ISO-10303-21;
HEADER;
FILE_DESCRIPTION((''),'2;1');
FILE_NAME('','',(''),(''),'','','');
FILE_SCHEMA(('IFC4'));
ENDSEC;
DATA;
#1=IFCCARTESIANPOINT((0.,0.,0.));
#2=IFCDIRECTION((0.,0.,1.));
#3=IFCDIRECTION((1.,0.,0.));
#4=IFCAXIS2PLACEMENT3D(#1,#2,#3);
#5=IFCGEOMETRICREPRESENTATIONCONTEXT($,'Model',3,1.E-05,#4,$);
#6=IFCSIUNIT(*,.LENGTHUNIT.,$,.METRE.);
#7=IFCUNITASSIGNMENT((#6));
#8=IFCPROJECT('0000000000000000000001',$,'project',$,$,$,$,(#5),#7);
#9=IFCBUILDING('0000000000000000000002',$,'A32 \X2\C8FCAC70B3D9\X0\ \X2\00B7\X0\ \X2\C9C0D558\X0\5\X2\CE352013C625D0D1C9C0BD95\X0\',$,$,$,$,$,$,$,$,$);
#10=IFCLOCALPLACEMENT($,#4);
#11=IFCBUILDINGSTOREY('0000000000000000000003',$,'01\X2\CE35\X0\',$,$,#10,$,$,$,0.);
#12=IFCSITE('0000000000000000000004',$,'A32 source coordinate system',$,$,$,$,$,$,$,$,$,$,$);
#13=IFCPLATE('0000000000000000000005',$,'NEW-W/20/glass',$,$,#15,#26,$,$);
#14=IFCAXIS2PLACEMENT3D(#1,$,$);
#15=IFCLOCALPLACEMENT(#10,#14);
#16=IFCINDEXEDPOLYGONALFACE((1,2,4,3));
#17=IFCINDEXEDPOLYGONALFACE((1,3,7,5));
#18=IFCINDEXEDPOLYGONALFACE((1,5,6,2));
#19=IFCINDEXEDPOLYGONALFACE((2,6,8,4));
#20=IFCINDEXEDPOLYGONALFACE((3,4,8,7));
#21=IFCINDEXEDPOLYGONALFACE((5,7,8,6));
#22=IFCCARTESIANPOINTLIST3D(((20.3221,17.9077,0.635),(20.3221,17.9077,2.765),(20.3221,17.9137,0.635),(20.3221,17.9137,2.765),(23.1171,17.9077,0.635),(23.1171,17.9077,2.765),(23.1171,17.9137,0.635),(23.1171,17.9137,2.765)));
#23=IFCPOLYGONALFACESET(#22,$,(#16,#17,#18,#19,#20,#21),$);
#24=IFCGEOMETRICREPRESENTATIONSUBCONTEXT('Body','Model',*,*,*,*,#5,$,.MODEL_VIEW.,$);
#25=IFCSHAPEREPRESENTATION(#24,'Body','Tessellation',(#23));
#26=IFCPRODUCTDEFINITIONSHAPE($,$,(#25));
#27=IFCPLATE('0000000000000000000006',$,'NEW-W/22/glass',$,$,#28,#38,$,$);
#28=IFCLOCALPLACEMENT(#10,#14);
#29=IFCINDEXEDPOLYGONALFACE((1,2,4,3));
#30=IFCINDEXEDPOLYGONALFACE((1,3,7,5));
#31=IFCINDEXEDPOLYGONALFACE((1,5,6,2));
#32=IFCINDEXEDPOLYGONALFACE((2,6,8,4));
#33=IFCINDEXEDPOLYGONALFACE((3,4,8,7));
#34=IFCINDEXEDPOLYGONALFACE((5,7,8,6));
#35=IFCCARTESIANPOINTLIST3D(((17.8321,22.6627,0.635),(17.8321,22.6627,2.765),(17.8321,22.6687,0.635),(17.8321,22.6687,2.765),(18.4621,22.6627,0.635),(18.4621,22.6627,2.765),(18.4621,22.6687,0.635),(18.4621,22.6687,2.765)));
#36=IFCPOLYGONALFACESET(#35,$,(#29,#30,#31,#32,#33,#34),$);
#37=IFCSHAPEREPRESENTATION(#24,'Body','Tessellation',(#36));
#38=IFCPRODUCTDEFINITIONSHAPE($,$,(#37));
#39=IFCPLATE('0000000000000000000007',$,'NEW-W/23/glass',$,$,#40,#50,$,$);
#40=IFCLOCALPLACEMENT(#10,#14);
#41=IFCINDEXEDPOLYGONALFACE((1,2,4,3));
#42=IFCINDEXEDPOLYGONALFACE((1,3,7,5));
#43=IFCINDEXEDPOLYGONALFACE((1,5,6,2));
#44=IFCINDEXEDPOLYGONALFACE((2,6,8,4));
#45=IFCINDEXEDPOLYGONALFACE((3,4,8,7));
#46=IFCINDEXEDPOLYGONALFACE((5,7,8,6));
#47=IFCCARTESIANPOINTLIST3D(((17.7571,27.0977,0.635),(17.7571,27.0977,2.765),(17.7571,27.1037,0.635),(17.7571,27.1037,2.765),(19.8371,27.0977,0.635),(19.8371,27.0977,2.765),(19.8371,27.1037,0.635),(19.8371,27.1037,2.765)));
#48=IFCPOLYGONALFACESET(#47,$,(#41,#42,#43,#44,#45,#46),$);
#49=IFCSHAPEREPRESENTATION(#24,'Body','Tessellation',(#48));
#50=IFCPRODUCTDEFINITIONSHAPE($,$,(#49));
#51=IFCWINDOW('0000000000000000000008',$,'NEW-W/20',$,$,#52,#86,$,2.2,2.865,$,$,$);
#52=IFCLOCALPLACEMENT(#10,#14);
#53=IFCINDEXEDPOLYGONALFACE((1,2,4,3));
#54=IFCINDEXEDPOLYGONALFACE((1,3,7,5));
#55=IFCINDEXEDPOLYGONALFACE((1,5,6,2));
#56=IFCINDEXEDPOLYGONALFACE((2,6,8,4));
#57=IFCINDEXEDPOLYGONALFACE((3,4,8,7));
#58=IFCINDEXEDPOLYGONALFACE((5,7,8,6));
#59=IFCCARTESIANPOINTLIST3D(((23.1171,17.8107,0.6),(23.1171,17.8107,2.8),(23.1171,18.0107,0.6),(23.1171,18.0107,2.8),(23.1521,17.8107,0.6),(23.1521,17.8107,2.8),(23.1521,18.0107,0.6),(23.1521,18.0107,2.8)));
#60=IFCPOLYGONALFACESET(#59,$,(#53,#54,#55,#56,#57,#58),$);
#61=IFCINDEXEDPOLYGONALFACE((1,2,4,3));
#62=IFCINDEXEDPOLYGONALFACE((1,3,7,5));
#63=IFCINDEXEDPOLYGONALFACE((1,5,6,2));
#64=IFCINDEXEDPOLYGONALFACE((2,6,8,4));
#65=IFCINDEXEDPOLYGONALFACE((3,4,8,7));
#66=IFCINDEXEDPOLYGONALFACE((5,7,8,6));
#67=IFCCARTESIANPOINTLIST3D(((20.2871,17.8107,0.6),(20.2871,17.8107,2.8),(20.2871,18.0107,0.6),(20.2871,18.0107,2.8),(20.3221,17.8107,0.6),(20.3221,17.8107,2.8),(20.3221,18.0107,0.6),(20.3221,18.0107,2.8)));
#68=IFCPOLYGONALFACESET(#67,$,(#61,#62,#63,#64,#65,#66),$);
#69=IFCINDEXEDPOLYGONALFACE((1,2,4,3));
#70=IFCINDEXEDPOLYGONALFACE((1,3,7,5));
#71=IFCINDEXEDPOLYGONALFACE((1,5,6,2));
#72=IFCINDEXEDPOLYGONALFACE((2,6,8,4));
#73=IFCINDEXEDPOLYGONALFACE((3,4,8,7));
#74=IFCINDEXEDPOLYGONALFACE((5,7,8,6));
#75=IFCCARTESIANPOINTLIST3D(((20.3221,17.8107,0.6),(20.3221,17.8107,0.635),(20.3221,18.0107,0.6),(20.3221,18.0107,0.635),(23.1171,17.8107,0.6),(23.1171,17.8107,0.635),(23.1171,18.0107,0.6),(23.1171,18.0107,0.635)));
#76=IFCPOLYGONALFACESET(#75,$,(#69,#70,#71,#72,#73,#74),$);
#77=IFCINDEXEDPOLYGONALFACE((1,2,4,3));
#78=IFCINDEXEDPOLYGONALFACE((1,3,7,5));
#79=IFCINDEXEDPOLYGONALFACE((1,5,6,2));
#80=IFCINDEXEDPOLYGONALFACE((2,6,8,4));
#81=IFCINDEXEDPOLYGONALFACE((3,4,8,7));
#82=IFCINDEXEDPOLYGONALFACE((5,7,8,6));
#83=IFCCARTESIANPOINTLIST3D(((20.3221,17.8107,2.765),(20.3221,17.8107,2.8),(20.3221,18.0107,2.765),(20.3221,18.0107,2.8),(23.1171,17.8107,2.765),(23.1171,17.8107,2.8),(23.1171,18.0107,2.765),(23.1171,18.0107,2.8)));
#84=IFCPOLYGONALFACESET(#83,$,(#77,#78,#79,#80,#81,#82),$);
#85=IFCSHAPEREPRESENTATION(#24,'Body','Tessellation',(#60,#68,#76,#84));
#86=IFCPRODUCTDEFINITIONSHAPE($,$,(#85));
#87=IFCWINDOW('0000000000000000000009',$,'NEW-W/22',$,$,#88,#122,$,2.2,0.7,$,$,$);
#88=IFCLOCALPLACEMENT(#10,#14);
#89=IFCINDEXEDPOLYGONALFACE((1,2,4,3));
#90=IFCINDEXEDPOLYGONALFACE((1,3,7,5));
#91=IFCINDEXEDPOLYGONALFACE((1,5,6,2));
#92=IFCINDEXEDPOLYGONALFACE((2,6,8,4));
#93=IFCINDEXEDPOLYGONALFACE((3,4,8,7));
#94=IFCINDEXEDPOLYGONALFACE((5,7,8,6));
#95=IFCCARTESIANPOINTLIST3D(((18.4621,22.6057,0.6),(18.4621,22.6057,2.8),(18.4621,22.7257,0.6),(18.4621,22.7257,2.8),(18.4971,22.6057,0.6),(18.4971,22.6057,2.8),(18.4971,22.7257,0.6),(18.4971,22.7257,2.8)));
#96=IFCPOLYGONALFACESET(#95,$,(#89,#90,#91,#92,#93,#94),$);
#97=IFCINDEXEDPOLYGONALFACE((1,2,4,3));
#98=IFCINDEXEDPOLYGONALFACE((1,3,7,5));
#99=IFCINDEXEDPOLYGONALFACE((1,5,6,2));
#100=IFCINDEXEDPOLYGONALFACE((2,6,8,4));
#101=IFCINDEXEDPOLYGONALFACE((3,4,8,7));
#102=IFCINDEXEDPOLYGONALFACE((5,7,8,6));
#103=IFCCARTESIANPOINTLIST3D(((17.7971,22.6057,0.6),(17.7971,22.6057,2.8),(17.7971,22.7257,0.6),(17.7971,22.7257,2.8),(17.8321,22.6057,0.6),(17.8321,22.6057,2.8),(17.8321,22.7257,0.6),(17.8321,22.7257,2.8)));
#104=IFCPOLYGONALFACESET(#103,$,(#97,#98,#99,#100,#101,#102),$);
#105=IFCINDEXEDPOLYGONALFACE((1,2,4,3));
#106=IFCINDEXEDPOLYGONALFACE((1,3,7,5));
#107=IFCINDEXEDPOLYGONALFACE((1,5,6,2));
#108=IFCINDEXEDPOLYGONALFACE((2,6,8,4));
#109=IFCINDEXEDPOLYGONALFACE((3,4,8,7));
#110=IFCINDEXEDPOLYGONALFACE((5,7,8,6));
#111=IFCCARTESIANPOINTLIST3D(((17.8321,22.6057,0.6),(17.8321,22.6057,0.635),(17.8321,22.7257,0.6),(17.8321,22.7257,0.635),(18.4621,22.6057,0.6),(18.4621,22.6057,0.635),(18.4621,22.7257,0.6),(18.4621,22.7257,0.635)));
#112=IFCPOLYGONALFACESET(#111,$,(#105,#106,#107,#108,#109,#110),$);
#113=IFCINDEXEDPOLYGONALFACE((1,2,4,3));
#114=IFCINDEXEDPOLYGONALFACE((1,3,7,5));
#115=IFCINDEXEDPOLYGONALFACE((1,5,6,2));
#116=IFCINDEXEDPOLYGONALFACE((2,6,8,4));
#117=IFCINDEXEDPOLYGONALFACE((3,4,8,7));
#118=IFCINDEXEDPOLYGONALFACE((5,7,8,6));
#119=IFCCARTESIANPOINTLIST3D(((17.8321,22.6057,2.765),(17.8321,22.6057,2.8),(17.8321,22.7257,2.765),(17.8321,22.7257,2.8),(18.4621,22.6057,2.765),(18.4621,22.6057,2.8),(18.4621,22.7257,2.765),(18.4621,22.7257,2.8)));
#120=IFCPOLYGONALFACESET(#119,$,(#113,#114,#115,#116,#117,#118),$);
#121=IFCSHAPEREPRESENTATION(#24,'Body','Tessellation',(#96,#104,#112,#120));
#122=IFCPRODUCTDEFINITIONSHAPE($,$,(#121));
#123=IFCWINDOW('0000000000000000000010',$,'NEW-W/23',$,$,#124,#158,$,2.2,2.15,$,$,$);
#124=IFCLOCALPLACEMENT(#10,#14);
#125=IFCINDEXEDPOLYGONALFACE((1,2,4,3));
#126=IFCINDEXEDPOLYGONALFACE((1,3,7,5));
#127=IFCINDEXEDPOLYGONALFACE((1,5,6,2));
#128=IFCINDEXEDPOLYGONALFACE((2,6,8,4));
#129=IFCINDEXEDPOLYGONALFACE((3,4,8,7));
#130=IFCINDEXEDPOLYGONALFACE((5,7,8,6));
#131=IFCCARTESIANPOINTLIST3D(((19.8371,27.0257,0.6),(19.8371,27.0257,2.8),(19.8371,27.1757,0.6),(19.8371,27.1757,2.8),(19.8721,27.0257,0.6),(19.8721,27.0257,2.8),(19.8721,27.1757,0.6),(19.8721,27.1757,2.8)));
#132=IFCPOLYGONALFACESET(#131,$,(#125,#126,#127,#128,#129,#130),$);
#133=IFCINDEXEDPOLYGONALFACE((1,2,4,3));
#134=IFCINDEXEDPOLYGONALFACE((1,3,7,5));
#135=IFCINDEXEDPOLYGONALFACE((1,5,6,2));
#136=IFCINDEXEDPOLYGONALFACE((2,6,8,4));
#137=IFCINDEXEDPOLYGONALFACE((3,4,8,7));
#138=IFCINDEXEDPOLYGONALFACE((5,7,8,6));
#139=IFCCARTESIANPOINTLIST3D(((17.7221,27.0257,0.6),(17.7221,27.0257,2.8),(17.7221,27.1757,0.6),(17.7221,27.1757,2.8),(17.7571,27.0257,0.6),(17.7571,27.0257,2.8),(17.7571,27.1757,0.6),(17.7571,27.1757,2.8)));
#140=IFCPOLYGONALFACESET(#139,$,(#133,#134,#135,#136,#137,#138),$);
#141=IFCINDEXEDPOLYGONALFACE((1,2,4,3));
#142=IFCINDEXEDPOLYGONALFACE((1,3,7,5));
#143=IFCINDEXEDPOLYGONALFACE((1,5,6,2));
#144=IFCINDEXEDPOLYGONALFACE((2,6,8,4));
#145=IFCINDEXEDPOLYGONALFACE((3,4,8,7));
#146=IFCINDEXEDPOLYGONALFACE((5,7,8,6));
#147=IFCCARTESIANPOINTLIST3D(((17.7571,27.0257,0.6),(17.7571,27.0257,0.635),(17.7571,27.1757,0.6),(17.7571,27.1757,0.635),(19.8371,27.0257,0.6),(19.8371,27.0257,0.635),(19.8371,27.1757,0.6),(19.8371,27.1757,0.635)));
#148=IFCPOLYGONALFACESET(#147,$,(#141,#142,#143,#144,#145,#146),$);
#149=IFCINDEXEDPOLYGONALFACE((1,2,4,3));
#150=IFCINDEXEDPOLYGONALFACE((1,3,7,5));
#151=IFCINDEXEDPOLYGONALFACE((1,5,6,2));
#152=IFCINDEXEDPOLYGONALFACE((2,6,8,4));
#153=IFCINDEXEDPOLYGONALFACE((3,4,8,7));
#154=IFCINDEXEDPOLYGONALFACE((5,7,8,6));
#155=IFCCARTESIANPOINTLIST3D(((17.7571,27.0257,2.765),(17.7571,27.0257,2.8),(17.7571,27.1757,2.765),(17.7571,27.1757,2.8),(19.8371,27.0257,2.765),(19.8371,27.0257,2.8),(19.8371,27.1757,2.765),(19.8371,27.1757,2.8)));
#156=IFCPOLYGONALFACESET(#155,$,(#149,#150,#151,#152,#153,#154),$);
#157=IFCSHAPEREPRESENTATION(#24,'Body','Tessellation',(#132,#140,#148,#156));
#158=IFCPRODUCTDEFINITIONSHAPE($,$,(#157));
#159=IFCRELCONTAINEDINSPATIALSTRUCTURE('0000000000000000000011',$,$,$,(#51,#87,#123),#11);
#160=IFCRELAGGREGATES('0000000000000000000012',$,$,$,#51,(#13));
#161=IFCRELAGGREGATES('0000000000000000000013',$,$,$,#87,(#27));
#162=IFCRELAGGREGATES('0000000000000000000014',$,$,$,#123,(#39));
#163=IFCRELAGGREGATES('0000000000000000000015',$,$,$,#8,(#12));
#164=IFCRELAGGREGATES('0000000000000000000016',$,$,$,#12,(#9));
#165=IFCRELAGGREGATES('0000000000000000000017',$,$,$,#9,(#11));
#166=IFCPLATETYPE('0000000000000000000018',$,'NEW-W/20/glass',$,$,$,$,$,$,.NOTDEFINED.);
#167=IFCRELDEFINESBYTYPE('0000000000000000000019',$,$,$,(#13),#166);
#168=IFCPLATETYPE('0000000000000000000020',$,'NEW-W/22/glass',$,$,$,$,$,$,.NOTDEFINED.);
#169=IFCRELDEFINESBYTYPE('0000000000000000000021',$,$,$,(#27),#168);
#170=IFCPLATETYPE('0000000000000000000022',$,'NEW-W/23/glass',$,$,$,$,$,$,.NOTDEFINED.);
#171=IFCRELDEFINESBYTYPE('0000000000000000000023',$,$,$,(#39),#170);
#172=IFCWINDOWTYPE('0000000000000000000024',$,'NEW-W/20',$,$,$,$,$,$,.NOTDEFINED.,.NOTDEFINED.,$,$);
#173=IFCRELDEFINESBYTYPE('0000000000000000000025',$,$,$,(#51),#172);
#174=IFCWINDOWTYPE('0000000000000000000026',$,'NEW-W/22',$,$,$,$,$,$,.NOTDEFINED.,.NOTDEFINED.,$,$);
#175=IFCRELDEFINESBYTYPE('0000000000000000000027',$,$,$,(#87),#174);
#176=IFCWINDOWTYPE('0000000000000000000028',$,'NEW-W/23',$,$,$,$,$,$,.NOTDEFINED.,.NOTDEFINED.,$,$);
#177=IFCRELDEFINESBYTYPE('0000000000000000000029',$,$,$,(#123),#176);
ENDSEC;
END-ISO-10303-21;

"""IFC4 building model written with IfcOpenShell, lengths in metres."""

from ifc_helpers import new_model, si_unit, frame, origin, origin_with_axes, place, context, subcontext, project, spatial, polyline, outline, extrude, source, transform, mapped, type_object, type_shapes, element, aggregate, save


model = new_model("IFC4")

# Units and contexts
model_context = context("Model", 3, precision=1e-05, world=origin_with_axes())
body_context = subcontext(model_context, "Body", "Model", "MODEL_VIEW")
ifc_project = project(units=[si_unit("LENGTHUNIT", "METRE")], contexts=[model_context])

# Plates
storey_placement = place(None, origin_with_axes())
plate_type_1 = type_object("IfcPlateType", Name="NEW-W/20/glass", PredefinedType="NOTDEFINED")
shared_shape_1 = source(origin(), body_context, "Body", "SweptSolid", [
    extrude(outline(polyline([(23.1171, 17.9077), (20.3221, 17.9077), (20.3221, 17.9137), (23.1171, 17.9137), (23.1171, 17.9077)])), frame((0.0, 0.0, 0.635)), (0.0, 0.0, 1.0), 2.13),
])
type_shapes(plate_type_1, [shared_shape_1])
window_1_placement = place(storey_placement, origin_with_axes())
plate_1_placement = place(window_1_placement, origin_with_axes())
plate_1 = element("IfcPlate", 1, at=plate_1_placement, type_object=plate_type_1, Name="NEW-W/20/glass", context=body_context, shape_type="MappedRepresentation", body=[
    mapped(shared_shape_1, transform((0.0, 0.0, 0.0), scale=1.0)),
])
plate_type_2 = type_object("IfcPlateType", Name="NEW-W/22/glass", PredefinedType="NOTDEFINED")
shared_shape_2 = source(origin(), body_context, "Body", "SweptSolid", [
    extrude(outline(polyline([(18.4621, 22.6627), (17.8321, 22.6627), (17.8321, 22.6687), (18.4621, 22.6687), (18.4621, 22.6627)])), frame((0.0, 0.0, 0.635)), (0.0, 0.0, 1.0), 2.13),
])
type_shapes(plate_type_2, [shared_shape_2])
window_2_placement = place(storey_placement, origin_with_axes())
plate_2_placement = place(window_2_placement, origin_with_axes())
plate_2 = element("IfcPlate", 2, at=plate_2_placement, type_object=plate_type_2, Name="NEW-W/22/glass", context=body_context, shape_type="MappedRepresentation", body=[
    mapped(shared_shape_2, transform((0.0, 0.0, 0.0), scale=1.0)),
])
plate_type_3 = type_object("IfcPlateType", Name="NEW-W/23/glass", PredefinedType="NOTDEFINED")
shared_shape_3 = source(origin(), body_context, "Body", "SweptSolid", [
    extrude(outline(polyline([(19.8371, 27.0977), (17.7571, 27.0977), (17.7571, 27.1037), (19.8371, 27.1037), (19.8371, 27.0977)])), frame((0.0, 0.0, 0.635)), (0.0, 0.0, 1.0), 2.13),
])
type_shapes(plate_type_3, [shared_shape_3])
window_3_placement = place(storey_placement, origin_with_axes())
plate_3_placement = place(window_3_placement, origin_with_axes())
plate_3 = element("IfcPlate", 3, at=plate_3_placement, type_object=plate_type_3, Name="NEW-W/23/glass", context=body_context, shape_type="MappedRepresentation", body=[
    mapped(shared_shape_3, transform((0.0, 0.0, 0.0), scale=1.0)),
])

# Site, building, storey
site = spatial("IfcSite", under=ifc_project, Name="A32 source coordinate system")
building = spatial("IfcBuilding", under=site, Name="A32 주거동 · 지하5층–옥탑지붕")
storey = spatial("IfcBuildingStorey", under=building, at=storey_placement, Name="01층", Elevation=0.0)

# Windows
window_type_1 = type_object("IfcWindowType", Name="NEW-W/20", PartitioningType="NOTDEFINED", PredefinedType="NOTDEFINED")
shared_shape_4 = source(origin(), body_context, "Body", "SweptSolid", [
    extrude(outline(polyline([(23.1171, 17.8107), (23.1171, 18.0107), (23.1521, 18.0107), (23.1521, 17.8107), (23.1171, 17.8107)])), frame((0.0, 0.0, 0.6)), (0.0, 0.0, 1.0), 2.2),
    extrude(outline(polyline([(20.2871, 17.8107), (20.2871, 18.0107), (20.3221, 18.0107), (20.3221, 17.8107), (20.2871, 17.8107)])), frame((0.0, 0.0, 0.6)), (0.0, 0.0, 1.0), 2.2),
    extrude(outline(polyline([(23.1171, 17.8107), (23.1171, 18.0107), (20.3221, 18.0107), (20.3221, 17.8107), (23.1171, 17.8107)])), frame((0.0, 0.0, 0.6)), (0.0, 0.0, 1.0), 0.035),
    extrude(outline(polyline([(23.1171, 17.8107), (23.1171, 18.0107), (20.3221, 18.0107), (20.3221, 17.8107), (23.1171, 17.8107)])), frame((0.0, 0.0, 2.765)), (0.0, 0.0, 1.0), 0.035),
])
type_shapes(window_type_1, [shared_shape_4])
window_1 = element("IfcWindow", 4, at=window_1_placement, inside=storey, type_object=window_type_1, Name="NEW-W/20", OverallHeight=2.2, OverallWidth=2.865, context=body_context, shape_type="MappedRepresentation", body=[
    mapped(shared_shape_4, transform((0.0, 0.0, 0.0), scale=1.0)),
])
aggregate(window_1, [plate_1])
window_type_2 = type_object("IfcWindowType", Name="NEW-W/22", PartitioningType="NOTDEFINED", PredefinedType="NOTDEFINED")
shared_shape_5 = source(origin(), body_context, "Body", "SweptSolid", [
    extrude(outline(polyline([(18.4621, 22.6057), (18.4621, 22.7257), (18.4971, 22.7257), (18.4971, 22.6057), (18.4621, 22.6057)])), frame((0.0, 0.0, 0.6)), (0.0, 0.0, 1.0), 2.2),
    extrude(outline(polyline([(17.7971, 22.6057), (17.7971, 22.7257), (17.8321, 22.7257), (17.8321, 22.6057), (17.7971, 22.6057)])), frame((0.0, 0.0, 0.6)), (0.0, 0.0, 1.0), 2.2),
    extrude(outline(polyline([(18.4621, 22.6057), (18.4621, 22.7257), (17.8321, 22.7257), (17.8321, 22.6057), (18.4621, 22.6057)])), frame((0.0, 0.0, 0.6)), (0.0, 0.0, 1.0), 0.035),
    extrude(outline(polyline([(18.4621, 22.6057), (18.4621, 22.7257), (17.8321, 22.7257), (17.8321, 22.6057), (18.4621, 22.6057)])), frame((0.0, 0.0, 2.765)), (0.0, 0.0, 1.0), 0.035),
])
type_shapes(window_type_2, [shared_shape_5])
window_2 = element("IfcWindow", 5, at=window_2_placement, inside=storey, type_object=window_type_2, Name="NEW-W/22", OverallHeight=2.2, OverallWidth=0.7, context=body_context, shape_type="MappedRepresentation", body=[
    mapped(shared_shape_5, transform((0.0, 0.0, 0.0), scale=1.0)),
])
aggregate(window_2, [plate_2])
window_type_3 = type_object("IfcWindowType", Name="NEW-W/23", PartitioningType="NOTDEFINED", PredefinedType="NOTDEFINED")
shared_shape_6 = source(origin(), body_context, "Body", "SweptSolid", [
    extrude(outline(polyline([(19.8371, 27.0257), (19.8371, 27.1757), (19.8721, 27.1757), (19.8721, 27.0257), (19.8371, 27.0257)])), frame((0.0, 0.0, 0.6)), (0.0, 0.0, 1.0), 2.2),
    extrude(outline(polyline([(17.7221, 27.0257), (17.7221, 27.1757), (17.7571, 27.1757), (17.7571, 27.0257), (17.7221, 27.0257)])), frame((0.0, 0.0, 0.6)), (0.0, 0.0, 1.0), 2.2),
    extrude(outline(polyline([(19.8371, 27.0257), (19.8371, 27.1757), (17.7571, 27.1757), (17.7571, 27.0257), (19.8371, 27.0257)])), frame((0.0, 0.0, 0.6)), (0.0, 0.0, 1.0), 0.035),
    extrude(outline(polyline([(19.8371, 27.0257), (19.8371, 27.1757), (17.7571, 27.1757), (17.7571, 27.0257), (19.8371, 27.0257)])), frame((0.0, 0.0, 2.765)), (0.0, 0.0, 1.0), 0.035),
])
type_shapes(window_type_3, [shared_shape_6])
window_3 = element("IfcWindow", 6, at=window_3_placement, inside=storey, type_object=window_type_3, Name="NEW-W/23", OverallHeight=2.2, OverallWidth=2.15, context=body_context, shape_type="MappedRepresentation", body=[
    mapped(shared_shape_6, transform((0.0, 0.0, 0.0), scale=1.0)),
])
aggregate(window_3, [plate_3])

save(model, "model.ifc")
